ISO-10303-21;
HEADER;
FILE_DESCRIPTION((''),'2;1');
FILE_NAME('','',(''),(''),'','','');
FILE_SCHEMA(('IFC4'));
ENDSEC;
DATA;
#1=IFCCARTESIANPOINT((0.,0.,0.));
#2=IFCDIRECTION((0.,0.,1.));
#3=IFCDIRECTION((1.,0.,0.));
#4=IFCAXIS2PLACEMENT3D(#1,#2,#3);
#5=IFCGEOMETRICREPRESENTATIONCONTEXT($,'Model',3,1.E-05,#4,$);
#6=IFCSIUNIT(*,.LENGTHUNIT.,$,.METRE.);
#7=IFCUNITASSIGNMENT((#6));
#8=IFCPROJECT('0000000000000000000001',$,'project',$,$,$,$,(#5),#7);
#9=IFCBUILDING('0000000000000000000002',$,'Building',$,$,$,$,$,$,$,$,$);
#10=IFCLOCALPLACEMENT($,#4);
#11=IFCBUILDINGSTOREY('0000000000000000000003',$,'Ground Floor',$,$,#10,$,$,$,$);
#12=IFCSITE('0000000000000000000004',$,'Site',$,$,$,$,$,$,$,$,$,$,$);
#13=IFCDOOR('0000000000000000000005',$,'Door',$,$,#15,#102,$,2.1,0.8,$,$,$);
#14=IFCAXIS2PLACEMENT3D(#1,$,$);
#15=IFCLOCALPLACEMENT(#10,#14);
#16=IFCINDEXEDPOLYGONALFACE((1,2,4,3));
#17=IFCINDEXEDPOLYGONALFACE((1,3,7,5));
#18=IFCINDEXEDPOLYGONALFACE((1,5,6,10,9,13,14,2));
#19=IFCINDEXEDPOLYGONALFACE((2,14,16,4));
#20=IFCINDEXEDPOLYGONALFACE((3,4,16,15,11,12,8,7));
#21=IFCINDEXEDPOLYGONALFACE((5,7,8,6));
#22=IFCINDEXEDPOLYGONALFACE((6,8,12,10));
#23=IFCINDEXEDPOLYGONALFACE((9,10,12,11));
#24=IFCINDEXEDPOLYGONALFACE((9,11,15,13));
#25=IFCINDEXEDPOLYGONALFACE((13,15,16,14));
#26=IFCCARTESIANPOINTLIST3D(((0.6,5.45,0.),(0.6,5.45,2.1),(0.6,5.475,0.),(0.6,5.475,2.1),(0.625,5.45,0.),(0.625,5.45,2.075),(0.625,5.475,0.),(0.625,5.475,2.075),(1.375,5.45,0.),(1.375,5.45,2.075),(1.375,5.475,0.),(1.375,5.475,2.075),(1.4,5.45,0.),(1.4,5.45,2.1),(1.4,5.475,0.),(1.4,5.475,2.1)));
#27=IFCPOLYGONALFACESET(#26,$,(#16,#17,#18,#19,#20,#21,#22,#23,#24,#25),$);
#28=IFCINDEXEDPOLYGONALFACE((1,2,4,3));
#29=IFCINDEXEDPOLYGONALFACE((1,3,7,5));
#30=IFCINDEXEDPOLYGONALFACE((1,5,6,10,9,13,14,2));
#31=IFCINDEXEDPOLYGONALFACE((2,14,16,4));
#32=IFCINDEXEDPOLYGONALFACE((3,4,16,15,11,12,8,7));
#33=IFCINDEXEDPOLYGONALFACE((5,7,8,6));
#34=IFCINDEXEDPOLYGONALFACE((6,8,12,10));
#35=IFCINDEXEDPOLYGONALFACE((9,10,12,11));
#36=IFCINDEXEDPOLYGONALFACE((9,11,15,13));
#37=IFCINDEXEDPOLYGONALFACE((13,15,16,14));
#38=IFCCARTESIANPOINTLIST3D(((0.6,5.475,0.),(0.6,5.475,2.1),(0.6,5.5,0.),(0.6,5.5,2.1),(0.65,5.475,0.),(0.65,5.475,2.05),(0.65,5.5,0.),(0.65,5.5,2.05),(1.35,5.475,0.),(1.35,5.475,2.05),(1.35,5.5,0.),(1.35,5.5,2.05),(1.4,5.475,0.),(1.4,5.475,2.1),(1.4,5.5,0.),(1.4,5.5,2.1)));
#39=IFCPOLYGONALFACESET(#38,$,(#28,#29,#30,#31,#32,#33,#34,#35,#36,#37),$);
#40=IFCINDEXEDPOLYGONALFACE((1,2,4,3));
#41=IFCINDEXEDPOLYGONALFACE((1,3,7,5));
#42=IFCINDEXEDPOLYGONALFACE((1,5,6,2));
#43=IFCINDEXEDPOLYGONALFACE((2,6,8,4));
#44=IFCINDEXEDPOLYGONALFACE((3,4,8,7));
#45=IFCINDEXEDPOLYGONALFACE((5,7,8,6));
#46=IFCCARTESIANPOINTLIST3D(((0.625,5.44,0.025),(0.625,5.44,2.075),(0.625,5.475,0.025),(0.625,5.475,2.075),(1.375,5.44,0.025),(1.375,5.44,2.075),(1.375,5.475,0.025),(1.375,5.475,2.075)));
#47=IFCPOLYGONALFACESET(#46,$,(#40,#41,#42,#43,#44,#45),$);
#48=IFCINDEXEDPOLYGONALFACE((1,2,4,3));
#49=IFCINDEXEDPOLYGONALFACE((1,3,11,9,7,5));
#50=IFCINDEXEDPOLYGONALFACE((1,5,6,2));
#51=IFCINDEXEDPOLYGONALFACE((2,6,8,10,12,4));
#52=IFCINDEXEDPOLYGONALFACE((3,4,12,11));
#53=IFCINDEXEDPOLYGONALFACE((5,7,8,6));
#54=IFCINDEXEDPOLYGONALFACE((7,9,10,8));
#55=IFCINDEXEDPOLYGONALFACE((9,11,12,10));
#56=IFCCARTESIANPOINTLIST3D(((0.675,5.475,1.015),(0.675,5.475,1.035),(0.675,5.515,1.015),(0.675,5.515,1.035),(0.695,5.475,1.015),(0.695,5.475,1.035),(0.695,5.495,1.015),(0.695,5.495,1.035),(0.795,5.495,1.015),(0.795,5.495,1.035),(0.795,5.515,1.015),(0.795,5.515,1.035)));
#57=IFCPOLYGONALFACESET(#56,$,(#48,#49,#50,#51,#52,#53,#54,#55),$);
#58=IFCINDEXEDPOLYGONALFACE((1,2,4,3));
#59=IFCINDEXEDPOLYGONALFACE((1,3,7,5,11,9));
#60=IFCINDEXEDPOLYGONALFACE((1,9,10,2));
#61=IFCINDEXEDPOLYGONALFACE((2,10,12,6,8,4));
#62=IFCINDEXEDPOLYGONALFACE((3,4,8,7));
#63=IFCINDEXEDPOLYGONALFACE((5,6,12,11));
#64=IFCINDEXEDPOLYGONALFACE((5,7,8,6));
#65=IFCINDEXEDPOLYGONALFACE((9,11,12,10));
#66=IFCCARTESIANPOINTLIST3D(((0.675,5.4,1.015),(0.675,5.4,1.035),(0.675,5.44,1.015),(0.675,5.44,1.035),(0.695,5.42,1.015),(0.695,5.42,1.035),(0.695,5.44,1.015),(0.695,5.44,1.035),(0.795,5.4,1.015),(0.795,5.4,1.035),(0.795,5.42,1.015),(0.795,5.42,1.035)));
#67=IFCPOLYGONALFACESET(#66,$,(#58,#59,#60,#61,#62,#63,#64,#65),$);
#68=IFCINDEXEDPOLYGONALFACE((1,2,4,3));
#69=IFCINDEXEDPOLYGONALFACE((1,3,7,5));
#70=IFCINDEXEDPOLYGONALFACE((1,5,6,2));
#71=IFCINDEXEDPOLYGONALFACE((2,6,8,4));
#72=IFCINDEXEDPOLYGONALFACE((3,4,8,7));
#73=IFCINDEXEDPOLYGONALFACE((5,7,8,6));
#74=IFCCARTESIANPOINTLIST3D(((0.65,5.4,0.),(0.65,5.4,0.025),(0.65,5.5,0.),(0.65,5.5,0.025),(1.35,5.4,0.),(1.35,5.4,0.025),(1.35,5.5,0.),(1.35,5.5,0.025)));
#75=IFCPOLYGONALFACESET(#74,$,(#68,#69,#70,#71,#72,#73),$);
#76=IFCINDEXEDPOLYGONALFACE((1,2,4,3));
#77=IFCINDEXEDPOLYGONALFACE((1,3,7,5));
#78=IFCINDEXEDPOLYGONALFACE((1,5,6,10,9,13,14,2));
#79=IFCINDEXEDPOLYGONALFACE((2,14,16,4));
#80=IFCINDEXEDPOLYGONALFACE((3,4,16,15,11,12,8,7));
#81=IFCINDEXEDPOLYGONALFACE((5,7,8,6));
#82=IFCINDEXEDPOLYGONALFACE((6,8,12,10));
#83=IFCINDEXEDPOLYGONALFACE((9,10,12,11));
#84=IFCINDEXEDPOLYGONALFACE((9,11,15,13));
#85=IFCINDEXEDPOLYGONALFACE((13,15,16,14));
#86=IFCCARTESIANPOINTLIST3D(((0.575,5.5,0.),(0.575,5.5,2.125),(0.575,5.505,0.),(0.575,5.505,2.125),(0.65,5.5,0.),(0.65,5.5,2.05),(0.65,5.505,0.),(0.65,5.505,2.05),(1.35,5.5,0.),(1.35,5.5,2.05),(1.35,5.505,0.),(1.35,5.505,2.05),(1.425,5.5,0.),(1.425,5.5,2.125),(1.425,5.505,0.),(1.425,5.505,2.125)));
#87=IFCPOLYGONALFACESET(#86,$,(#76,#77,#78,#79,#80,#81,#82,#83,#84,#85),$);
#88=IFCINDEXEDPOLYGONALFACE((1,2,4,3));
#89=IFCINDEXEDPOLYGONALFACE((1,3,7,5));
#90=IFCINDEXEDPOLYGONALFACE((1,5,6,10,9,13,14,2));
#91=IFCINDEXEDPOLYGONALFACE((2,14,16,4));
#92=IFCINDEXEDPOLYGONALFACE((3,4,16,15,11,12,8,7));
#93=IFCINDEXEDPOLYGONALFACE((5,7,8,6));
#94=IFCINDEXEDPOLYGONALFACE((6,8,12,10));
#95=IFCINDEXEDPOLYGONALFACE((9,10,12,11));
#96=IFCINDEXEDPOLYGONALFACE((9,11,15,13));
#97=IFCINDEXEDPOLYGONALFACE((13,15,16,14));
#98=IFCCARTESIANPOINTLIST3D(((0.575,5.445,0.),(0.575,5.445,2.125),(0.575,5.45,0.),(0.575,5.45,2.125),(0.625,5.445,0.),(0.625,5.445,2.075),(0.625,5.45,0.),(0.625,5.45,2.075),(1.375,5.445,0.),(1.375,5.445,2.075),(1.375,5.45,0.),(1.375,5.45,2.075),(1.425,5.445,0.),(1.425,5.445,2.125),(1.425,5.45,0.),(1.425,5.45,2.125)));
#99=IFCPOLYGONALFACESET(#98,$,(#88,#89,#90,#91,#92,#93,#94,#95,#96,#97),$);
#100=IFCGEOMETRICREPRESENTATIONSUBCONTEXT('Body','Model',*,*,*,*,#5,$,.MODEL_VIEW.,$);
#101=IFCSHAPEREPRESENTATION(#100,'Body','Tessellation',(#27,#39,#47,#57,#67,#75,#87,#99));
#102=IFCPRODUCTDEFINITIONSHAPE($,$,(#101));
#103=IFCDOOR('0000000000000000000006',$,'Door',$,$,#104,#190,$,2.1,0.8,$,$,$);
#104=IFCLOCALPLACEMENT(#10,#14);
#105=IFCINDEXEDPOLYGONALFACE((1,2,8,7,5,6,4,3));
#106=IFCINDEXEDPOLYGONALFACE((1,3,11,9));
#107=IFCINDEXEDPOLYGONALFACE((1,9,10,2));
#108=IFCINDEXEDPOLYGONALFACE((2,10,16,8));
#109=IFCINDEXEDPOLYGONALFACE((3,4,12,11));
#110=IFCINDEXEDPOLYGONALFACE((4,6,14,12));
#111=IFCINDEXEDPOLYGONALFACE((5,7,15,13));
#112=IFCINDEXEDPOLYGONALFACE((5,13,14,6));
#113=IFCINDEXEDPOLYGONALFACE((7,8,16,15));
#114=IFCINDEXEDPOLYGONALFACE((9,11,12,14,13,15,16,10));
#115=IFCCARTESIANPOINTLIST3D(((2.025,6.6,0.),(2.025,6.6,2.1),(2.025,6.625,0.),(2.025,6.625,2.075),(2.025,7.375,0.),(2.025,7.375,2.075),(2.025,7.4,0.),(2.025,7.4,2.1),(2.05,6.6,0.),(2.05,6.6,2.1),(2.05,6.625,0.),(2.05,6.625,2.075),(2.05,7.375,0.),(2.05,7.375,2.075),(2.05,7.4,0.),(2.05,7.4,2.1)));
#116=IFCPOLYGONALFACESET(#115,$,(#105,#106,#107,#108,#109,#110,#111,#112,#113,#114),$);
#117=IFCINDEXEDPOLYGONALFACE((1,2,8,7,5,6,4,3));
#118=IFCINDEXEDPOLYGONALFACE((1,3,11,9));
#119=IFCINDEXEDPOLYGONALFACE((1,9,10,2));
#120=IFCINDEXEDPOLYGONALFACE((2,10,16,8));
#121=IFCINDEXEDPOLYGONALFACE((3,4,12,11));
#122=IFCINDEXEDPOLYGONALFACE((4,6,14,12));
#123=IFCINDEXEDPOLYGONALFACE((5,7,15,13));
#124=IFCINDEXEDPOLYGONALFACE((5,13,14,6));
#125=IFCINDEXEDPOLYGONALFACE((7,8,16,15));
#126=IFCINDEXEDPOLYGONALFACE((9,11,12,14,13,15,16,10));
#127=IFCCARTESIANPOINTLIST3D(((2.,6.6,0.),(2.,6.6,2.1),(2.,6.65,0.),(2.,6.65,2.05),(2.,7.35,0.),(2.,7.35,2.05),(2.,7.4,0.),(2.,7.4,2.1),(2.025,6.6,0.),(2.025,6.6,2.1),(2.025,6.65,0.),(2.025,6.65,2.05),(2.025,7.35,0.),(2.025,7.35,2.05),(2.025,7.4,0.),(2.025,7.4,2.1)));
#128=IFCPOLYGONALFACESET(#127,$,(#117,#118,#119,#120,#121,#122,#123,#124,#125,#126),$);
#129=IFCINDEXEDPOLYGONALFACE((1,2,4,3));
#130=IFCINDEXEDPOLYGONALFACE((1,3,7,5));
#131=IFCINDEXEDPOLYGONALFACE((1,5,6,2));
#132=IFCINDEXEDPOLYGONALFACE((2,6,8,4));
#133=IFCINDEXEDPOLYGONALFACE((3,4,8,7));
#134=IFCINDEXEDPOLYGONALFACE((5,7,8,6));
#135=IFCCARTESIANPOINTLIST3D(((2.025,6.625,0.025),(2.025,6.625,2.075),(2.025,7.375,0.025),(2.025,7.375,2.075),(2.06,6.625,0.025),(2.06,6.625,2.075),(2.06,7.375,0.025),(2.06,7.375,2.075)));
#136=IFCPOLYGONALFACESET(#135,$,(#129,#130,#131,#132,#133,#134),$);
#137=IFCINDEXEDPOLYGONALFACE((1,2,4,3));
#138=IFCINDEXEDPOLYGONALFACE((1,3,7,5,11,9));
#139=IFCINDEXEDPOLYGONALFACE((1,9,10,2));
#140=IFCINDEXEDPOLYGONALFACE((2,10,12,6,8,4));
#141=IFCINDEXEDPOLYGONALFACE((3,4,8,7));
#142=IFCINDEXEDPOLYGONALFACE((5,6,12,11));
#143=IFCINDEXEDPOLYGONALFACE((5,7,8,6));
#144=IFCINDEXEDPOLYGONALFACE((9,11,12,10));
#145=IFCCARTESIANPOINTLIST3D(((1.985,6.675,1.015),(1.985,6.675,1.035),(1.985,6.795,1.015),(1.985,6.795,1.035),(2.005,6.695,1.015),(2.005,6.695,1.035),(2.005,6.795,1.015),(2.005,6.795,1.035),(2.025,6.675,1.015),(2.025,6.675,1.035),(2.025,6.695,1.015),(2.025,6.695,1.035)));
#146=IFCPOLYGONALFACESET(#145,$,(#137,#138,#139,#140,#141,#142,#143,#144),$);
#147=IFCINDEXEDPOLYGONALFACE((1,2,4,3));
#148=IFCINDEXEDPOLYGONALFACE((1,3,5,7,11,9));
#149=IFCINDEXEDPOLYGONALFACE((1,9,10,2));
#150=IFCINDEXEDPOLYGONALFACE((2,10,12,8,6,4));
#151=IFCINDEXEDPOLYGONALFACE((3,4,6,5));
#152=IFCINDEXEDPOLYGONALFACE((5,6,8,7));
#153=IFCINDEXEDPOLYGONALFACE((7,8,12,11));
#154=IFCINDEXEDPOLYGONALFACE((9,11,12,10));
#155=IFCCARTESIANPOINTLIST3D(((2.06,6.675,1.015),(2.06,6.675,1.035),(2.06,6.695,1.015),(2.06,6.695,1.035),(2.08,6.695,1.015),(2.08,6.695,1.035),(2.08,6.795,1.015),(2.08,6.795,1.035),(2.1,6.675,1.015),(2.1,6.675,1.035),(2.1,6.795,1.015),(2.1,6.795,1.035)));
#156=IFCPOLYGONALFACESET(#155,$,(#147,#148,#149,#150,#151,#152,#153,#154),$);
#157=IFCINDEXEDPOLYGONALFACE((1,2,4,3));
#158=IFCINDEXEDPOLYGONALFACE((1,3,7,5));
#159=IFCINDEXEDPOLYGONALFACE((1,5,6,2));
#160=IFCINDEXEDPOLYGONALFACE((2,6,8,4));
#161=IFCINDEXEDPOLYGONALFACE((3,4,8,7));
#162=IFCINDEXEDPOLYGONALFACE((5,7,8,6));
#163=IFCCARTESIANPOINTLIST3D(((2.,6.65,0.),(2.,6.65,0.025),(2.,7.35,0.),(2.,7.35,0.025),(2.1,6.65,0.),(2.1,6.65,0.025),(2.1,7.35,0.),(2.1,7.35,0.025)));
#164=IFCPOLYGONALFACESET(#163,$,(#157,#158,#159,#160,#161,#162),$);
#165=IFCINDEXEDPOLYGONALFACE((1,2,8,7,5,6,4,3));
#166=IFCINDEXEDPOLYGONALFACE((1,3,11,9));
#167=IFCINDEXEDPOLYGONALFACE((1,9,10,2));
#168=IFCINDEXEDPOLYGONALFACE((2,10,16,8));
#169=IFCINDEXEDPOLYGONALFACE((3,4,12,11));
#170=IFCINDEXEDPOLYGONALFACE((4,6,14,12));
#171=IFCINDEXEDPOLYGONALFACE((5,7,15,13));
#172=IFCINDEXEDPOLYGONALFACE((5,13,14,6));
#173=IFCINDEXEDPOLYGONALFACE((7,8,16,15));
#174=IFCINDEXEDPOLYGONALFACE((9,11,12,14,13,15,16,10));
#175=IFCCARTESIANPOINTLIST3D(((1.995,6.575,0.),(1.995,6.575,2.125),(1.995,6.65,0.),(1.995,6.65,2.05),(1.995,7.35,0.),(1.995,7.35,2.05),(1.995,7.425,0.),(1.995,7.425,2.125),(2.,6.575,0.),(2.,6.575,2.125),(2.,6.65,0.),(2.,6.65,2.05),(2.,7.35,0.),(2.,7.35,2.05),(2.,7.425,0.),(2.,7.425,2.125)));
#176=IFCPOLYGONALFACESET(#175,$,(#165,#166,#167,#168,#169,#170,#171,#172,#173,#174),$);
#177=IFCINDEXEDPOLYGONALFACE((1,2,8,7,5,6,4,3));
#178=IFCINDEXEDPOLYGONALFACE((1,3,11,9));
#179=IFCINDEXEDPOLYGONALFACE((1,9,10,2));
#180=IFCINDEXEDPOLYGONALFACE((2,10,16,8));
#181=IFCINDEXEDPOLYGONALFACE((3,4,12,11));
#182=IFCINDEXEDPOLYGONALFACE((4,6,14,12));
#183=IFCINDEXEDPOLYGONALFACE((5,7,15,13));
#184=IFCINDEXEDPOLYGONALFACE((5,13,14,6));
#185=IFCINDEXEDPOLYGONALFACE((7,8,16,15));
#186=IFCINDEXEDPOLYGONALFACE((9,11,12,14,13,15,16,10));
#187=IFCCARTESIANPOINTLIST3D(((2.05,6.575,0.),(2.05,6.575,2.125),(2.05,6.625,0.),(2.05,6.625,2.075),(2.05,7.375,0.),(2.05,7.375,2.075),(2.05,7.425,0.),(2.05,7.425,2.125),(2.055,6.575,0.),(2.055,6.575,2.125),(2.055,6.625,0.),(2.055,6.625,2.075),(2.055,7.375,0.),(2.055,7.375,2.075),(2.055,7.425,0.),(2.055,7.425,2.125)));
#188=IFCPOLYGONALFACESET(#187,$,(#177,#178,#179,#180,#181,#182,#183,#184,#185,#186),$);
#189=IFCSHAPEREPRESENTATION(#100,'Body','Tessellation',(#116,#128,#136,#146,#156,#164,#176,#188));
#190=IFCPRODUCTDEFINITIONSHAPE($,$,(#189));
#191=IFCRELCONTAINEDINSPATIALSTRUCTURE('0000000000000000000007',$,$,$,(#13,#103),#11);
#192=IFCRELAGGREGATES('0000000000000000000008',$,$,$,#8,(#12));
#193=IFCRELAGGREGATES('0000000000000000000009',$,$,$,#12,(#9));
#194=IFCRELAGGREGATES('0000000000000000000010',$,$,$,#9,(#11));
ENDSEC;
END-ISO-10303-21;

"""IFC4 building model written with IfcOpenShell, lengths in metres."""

from ifc_helpers import new_model, si_unit, frame, origin_with_axes, place, context, subcontext, project, spatial, line, indexed_curve, outline, extrude, element, save


model = new_model("IFC4")

# Units and contexts
model_context = context("Model", 3, precision=1e-05, world=origin_with_axes())
body_context = subcontext(model_context, "Body", "Model", "MODEL_VIEW")
ifc_project = project(units=[si_unit("LENGTHUNIT", "METRE")], contexts=[model_context])

# Site, building, storey
site = spatial("IfcSite", under=ifc_project, Name="Site")
building = spatial("IfcBuilding", under=site, Name="Building")
storey_placement = place(None, origin_with_axes())
storey = spatial("IfcBuildingStorey", under=building, at=storey_placement, Name="Ground Floor")

# Doors
door_1_placement = place(storey_placement, frame((1.4, 5.5, 0.0), z_axis=(0.0, 0.0, 1.0), x_axis=(-1.0, 0.0, 0.0)))
element("IfcDoor", 1, at=door_1_placement, inside=storey, Name="Door", OverallHeight=2.1, OverallWidth=0.8, context=body_context, shape_type="SweptSolid", body=[
    extrude(outline(indexed_curve([(0.0, 0.0), (0.0, 2.1), (0.8, 2.1), (0.8, 0.0), (0.775, 0.0), (0.775, 2.075), (0.025, 2.075), (0.025, 0.0)], segments=[line(1, 2, 3, 4, 5, 6, 7, 8, 1)])), frame((0.0, 0.025, 0.0), z_axis=(0.0, -1.0, 0.0), x_axis=(1.0, 0.0, 0.0)), (0.0, 0.0, -1.0), 0.025),
    extrude(outline(indexed_curve([(0.0, 0.0), (0.0, 2.1), (0.8, 2.1), (0.8, 0.0), (0.75, 0.0), (0.75, 2.05), (0.05, 2.05), (0.05, 0.0)], segments=[line(1, 2, 3, 4, 5, 6, 7, 8, 1)])), frame((0.0, 0.0, 0.0), z_axis=(0.0, -1.0, 0.0), x_axis=(1.0, 0.0, 0.0)), (0.0, 0.0, -1.0), 0.025),
    extrude(outline(indexed_curve([(0.0, 0.0), (0.75, 0.0), (0.75, 0.035), (0.0, 0.035)], segments=[line(1, 2, 3, 4, 1)])), frame((0.025, 0.025, 0.025), z_axis=(0.0, 0.0, 1.0), x_axis=(1.0, 0.0, 0.0)), (0.0, 0.0, 1.0), 2.05),
    extrude(outline(indexed_curve([(0.0, 0.0), (0.0, -0.04), (-0.12, -0.04), (-0.12, -0.02), (-0.02, -0.02), (-0.02, 0.0)], segments=[line(1, 2, 3, 4, 5, 6, 1)])), frame((0.725, 0.025, 1.015), z_axis=(0.0, 0.0, 1.0), x_axis=(1.0, 0.0, 0.0)), (0.0, 0.0, 1.0), 0.02),
    extrude(outline(indexed_curve([(0.0, 0.0), (0.0, 0.04), (-0.12, 0.04), (-0.12, 0.02), (-0.02, 0.02), (-0.02, 0.0)], segments=[line(1, 2, 3, 4, 5, 6, 1)])), frame((0.725, 0.06, 1.015), z_axis=(0.0, 0.0, 1.0), x_axis=(1.0, 0.0, 0.0)), (0.0, 0.0, 1.0), 0.02),
    extrude(outline(indexed_curve([(0.0, 0.0), (0.7, 0.0), (0.7, 0.1), (0.0, 0.1)], segments=[line(1, 2, 3, 4, 1)])), frame((0.05, 0.0, 0.0), z_axis=(0.0, 0.0, 1.0), x_axis=(1.0, 0.0, 0.0)), (0.0, 0.0, 1.0), 0.025),
    extrude(outline(indexed_curve([(0.0, 0.0), (0.0, 2.125), (0.85, 2.125), (0.85, 0.0), (0.775, 0.0), (0.775, 2.05), (0.075, 2.05), (0.075, 0.0)], segments=[line(1, 2, 3, 4, 5, 6, 7, 8, 1)])), frame((-0.025, -0.005, 0.0), z_axis=(0.0, -1.0, 0.0), x_axis=(1.0, 0.0, 0.0)), (0.0, 0.0, -1.0), 0.005),
    extrude(outline(indexed_curve([(0.0, 0.0), (0.0, 2.125), (0.85, 2.125), (0.85, 0.0), (0.8, 0.0), (0.8, 2.075), (0.05, 2.075), (0.05, 0.0)], segments=[line(1, 2, 3, 4, 5, 6, 7, 8, 1)])), frame((-0.025, 0.05, 0.0), z_axis=(0.0, -1.0, 0.0), x_axis=(1.0, 0.0, 0.0)), (0.0, 0.0, -1.0), 0.005),
])
door_2_placement = place(storey_placement, frame((2.0, 7.4, 0.0), z_axis=(0.0, 0.0, 1.0), x_axis=(0.0, -1.0, 0.0)))
element("IfcDoor", 2, at=door_2_placement, inside=storey, Name="Door", OverallHeight=2.1, OverallWidth=0.8, context=body_context, shape_type="SweptSolid", body=[
    extrude(outline(indexed_curve([(0.0, 0.0), (0.0, 2.1), (0.8, 2.1), (0.8, 0.0), (0.775, 0.0), (0.775, 2.075), (0.025, 2.075), (0.025, 0.0)], segments=[line(1, 2, 3, 4, 5, 6, 7, 8, 1)])), frame((0.0, 0.025, 0.0), z_axis=(0.0, -1.0, 0.0), x_axis=(1.0, 0.0, 0.0)), (0.0, 0.0, -1.0), 0.025),
    extrude(outline(indexed_curve([(0.0, 0.0), (0.0, 2.1), (0.8, 2.1), (0.8, 0.0), (0.75, 0.0), (0.75, 2.05), (0.05, 2.05), (0.05, 0.0)], segments=[line(1, 2, 3, 4, 5, 6, 7, 8, 1)])), frame((0.0, 0.0, 0.0), z_axis=(0.0, -1.0, 0.0), x_axis=(1.0, 0.0, 0.0)), (0.0, 0.0, -1.0), 0.025),
    extrude(outline(indexed_curve([(0.0, 0.0), (0.75, 0.0), (0.75, 0.035), (0.0, 0.035)], segments=[line(1, 2, 3, 4, 1)])), frame((0.025, 0.025, 0.025), z_axis=(0.0, 0.0, 1.0), x_axis=(1.0, 0.0, 0.0)), (0.0, 0.0, 1.0), 2.05),
    extrude(outline(indexed_curve([(0.0, 0.0), (0.0, -0.04), (-0.12, -0.04), (-0.12, -0.02), (-0.02, -0.02), (-0.02, 0.0)], segments=[line(1, 2, 3, 4, 5, 6, 1)])), frame((0.725, 0.025, 1.015), z_axis=(0.0, 0.0, 1.0), x_axis=(1.0, 0.0, 0.0)), (0.0, 0.0, 1.0), 0.02),
    extrude(outline(indexed_curve([(0.0, 0.0), (0.0, 0.04), (-0.12, 0.04), (-0.12, 0.02), (-0.02, 0.02), (-0.02, 0.0)], segments=[line(1, 2, 3, 4, 5, 6, 1)])), frame((0.725, 0.06, 1.015), z_axis=(0.0, 0.0, 1.0), x_axis=(1.0, 0.0, 0.0)), (0.0, 0.0, 1.0), 0.02),
    extrude(outline(indexed_curve([(0.0, 0.0), (0.7, 0.0), (0.7, 0.1), (0.0, 0.1)], segments=[line(1, 2, 3, 4, 1)])), frame((0.05, 0.0, 0.0), z_axis=(0.0, 0.0, 1.0), x_axis=(1.0, 0.0, 0.0)), (0.0, 0.0, 1.0), 0.025),
    extrude(outline(indexed_curve([(0.0, 0.0), (0.0, 2.125), (0.85, 2.125), (0.85, 0.0), (0.775, 0.0), (0.775, 2.05), (0.075, 2.05), (0.075, 0.0)], segments=[line(1, 2, 3, 4, 5, 6, 7, 8, 1)])), frame((-0.025, -0.005, 0.0), z_axis=(0.0, -1.0, 0.0), x_axis=(1.0, 0.0, 0.0)), (0.0, 0.0, -1.0), 0.005),
    extrude(outline(indexed_curve([(0.0, 0.0), (0.0, 2.125), (0.85, 2.125), (0.85, 0.0), (0.8, 0.0), (0.8, 2.075), (0.05, 2.075), (0.05, 0.0)], segments=[line(1, 2, 3, 4, 5, 6, 7, 8, 1)])), frame((-0.025, 0.05, 0.0), z_axis=(0.0, -1.0, 0.0), x_axis=(1.0, 0.0, 0.0)), (0.0, 0.0, -1.0), 0.005),
])

save(model, "model.ifc")
